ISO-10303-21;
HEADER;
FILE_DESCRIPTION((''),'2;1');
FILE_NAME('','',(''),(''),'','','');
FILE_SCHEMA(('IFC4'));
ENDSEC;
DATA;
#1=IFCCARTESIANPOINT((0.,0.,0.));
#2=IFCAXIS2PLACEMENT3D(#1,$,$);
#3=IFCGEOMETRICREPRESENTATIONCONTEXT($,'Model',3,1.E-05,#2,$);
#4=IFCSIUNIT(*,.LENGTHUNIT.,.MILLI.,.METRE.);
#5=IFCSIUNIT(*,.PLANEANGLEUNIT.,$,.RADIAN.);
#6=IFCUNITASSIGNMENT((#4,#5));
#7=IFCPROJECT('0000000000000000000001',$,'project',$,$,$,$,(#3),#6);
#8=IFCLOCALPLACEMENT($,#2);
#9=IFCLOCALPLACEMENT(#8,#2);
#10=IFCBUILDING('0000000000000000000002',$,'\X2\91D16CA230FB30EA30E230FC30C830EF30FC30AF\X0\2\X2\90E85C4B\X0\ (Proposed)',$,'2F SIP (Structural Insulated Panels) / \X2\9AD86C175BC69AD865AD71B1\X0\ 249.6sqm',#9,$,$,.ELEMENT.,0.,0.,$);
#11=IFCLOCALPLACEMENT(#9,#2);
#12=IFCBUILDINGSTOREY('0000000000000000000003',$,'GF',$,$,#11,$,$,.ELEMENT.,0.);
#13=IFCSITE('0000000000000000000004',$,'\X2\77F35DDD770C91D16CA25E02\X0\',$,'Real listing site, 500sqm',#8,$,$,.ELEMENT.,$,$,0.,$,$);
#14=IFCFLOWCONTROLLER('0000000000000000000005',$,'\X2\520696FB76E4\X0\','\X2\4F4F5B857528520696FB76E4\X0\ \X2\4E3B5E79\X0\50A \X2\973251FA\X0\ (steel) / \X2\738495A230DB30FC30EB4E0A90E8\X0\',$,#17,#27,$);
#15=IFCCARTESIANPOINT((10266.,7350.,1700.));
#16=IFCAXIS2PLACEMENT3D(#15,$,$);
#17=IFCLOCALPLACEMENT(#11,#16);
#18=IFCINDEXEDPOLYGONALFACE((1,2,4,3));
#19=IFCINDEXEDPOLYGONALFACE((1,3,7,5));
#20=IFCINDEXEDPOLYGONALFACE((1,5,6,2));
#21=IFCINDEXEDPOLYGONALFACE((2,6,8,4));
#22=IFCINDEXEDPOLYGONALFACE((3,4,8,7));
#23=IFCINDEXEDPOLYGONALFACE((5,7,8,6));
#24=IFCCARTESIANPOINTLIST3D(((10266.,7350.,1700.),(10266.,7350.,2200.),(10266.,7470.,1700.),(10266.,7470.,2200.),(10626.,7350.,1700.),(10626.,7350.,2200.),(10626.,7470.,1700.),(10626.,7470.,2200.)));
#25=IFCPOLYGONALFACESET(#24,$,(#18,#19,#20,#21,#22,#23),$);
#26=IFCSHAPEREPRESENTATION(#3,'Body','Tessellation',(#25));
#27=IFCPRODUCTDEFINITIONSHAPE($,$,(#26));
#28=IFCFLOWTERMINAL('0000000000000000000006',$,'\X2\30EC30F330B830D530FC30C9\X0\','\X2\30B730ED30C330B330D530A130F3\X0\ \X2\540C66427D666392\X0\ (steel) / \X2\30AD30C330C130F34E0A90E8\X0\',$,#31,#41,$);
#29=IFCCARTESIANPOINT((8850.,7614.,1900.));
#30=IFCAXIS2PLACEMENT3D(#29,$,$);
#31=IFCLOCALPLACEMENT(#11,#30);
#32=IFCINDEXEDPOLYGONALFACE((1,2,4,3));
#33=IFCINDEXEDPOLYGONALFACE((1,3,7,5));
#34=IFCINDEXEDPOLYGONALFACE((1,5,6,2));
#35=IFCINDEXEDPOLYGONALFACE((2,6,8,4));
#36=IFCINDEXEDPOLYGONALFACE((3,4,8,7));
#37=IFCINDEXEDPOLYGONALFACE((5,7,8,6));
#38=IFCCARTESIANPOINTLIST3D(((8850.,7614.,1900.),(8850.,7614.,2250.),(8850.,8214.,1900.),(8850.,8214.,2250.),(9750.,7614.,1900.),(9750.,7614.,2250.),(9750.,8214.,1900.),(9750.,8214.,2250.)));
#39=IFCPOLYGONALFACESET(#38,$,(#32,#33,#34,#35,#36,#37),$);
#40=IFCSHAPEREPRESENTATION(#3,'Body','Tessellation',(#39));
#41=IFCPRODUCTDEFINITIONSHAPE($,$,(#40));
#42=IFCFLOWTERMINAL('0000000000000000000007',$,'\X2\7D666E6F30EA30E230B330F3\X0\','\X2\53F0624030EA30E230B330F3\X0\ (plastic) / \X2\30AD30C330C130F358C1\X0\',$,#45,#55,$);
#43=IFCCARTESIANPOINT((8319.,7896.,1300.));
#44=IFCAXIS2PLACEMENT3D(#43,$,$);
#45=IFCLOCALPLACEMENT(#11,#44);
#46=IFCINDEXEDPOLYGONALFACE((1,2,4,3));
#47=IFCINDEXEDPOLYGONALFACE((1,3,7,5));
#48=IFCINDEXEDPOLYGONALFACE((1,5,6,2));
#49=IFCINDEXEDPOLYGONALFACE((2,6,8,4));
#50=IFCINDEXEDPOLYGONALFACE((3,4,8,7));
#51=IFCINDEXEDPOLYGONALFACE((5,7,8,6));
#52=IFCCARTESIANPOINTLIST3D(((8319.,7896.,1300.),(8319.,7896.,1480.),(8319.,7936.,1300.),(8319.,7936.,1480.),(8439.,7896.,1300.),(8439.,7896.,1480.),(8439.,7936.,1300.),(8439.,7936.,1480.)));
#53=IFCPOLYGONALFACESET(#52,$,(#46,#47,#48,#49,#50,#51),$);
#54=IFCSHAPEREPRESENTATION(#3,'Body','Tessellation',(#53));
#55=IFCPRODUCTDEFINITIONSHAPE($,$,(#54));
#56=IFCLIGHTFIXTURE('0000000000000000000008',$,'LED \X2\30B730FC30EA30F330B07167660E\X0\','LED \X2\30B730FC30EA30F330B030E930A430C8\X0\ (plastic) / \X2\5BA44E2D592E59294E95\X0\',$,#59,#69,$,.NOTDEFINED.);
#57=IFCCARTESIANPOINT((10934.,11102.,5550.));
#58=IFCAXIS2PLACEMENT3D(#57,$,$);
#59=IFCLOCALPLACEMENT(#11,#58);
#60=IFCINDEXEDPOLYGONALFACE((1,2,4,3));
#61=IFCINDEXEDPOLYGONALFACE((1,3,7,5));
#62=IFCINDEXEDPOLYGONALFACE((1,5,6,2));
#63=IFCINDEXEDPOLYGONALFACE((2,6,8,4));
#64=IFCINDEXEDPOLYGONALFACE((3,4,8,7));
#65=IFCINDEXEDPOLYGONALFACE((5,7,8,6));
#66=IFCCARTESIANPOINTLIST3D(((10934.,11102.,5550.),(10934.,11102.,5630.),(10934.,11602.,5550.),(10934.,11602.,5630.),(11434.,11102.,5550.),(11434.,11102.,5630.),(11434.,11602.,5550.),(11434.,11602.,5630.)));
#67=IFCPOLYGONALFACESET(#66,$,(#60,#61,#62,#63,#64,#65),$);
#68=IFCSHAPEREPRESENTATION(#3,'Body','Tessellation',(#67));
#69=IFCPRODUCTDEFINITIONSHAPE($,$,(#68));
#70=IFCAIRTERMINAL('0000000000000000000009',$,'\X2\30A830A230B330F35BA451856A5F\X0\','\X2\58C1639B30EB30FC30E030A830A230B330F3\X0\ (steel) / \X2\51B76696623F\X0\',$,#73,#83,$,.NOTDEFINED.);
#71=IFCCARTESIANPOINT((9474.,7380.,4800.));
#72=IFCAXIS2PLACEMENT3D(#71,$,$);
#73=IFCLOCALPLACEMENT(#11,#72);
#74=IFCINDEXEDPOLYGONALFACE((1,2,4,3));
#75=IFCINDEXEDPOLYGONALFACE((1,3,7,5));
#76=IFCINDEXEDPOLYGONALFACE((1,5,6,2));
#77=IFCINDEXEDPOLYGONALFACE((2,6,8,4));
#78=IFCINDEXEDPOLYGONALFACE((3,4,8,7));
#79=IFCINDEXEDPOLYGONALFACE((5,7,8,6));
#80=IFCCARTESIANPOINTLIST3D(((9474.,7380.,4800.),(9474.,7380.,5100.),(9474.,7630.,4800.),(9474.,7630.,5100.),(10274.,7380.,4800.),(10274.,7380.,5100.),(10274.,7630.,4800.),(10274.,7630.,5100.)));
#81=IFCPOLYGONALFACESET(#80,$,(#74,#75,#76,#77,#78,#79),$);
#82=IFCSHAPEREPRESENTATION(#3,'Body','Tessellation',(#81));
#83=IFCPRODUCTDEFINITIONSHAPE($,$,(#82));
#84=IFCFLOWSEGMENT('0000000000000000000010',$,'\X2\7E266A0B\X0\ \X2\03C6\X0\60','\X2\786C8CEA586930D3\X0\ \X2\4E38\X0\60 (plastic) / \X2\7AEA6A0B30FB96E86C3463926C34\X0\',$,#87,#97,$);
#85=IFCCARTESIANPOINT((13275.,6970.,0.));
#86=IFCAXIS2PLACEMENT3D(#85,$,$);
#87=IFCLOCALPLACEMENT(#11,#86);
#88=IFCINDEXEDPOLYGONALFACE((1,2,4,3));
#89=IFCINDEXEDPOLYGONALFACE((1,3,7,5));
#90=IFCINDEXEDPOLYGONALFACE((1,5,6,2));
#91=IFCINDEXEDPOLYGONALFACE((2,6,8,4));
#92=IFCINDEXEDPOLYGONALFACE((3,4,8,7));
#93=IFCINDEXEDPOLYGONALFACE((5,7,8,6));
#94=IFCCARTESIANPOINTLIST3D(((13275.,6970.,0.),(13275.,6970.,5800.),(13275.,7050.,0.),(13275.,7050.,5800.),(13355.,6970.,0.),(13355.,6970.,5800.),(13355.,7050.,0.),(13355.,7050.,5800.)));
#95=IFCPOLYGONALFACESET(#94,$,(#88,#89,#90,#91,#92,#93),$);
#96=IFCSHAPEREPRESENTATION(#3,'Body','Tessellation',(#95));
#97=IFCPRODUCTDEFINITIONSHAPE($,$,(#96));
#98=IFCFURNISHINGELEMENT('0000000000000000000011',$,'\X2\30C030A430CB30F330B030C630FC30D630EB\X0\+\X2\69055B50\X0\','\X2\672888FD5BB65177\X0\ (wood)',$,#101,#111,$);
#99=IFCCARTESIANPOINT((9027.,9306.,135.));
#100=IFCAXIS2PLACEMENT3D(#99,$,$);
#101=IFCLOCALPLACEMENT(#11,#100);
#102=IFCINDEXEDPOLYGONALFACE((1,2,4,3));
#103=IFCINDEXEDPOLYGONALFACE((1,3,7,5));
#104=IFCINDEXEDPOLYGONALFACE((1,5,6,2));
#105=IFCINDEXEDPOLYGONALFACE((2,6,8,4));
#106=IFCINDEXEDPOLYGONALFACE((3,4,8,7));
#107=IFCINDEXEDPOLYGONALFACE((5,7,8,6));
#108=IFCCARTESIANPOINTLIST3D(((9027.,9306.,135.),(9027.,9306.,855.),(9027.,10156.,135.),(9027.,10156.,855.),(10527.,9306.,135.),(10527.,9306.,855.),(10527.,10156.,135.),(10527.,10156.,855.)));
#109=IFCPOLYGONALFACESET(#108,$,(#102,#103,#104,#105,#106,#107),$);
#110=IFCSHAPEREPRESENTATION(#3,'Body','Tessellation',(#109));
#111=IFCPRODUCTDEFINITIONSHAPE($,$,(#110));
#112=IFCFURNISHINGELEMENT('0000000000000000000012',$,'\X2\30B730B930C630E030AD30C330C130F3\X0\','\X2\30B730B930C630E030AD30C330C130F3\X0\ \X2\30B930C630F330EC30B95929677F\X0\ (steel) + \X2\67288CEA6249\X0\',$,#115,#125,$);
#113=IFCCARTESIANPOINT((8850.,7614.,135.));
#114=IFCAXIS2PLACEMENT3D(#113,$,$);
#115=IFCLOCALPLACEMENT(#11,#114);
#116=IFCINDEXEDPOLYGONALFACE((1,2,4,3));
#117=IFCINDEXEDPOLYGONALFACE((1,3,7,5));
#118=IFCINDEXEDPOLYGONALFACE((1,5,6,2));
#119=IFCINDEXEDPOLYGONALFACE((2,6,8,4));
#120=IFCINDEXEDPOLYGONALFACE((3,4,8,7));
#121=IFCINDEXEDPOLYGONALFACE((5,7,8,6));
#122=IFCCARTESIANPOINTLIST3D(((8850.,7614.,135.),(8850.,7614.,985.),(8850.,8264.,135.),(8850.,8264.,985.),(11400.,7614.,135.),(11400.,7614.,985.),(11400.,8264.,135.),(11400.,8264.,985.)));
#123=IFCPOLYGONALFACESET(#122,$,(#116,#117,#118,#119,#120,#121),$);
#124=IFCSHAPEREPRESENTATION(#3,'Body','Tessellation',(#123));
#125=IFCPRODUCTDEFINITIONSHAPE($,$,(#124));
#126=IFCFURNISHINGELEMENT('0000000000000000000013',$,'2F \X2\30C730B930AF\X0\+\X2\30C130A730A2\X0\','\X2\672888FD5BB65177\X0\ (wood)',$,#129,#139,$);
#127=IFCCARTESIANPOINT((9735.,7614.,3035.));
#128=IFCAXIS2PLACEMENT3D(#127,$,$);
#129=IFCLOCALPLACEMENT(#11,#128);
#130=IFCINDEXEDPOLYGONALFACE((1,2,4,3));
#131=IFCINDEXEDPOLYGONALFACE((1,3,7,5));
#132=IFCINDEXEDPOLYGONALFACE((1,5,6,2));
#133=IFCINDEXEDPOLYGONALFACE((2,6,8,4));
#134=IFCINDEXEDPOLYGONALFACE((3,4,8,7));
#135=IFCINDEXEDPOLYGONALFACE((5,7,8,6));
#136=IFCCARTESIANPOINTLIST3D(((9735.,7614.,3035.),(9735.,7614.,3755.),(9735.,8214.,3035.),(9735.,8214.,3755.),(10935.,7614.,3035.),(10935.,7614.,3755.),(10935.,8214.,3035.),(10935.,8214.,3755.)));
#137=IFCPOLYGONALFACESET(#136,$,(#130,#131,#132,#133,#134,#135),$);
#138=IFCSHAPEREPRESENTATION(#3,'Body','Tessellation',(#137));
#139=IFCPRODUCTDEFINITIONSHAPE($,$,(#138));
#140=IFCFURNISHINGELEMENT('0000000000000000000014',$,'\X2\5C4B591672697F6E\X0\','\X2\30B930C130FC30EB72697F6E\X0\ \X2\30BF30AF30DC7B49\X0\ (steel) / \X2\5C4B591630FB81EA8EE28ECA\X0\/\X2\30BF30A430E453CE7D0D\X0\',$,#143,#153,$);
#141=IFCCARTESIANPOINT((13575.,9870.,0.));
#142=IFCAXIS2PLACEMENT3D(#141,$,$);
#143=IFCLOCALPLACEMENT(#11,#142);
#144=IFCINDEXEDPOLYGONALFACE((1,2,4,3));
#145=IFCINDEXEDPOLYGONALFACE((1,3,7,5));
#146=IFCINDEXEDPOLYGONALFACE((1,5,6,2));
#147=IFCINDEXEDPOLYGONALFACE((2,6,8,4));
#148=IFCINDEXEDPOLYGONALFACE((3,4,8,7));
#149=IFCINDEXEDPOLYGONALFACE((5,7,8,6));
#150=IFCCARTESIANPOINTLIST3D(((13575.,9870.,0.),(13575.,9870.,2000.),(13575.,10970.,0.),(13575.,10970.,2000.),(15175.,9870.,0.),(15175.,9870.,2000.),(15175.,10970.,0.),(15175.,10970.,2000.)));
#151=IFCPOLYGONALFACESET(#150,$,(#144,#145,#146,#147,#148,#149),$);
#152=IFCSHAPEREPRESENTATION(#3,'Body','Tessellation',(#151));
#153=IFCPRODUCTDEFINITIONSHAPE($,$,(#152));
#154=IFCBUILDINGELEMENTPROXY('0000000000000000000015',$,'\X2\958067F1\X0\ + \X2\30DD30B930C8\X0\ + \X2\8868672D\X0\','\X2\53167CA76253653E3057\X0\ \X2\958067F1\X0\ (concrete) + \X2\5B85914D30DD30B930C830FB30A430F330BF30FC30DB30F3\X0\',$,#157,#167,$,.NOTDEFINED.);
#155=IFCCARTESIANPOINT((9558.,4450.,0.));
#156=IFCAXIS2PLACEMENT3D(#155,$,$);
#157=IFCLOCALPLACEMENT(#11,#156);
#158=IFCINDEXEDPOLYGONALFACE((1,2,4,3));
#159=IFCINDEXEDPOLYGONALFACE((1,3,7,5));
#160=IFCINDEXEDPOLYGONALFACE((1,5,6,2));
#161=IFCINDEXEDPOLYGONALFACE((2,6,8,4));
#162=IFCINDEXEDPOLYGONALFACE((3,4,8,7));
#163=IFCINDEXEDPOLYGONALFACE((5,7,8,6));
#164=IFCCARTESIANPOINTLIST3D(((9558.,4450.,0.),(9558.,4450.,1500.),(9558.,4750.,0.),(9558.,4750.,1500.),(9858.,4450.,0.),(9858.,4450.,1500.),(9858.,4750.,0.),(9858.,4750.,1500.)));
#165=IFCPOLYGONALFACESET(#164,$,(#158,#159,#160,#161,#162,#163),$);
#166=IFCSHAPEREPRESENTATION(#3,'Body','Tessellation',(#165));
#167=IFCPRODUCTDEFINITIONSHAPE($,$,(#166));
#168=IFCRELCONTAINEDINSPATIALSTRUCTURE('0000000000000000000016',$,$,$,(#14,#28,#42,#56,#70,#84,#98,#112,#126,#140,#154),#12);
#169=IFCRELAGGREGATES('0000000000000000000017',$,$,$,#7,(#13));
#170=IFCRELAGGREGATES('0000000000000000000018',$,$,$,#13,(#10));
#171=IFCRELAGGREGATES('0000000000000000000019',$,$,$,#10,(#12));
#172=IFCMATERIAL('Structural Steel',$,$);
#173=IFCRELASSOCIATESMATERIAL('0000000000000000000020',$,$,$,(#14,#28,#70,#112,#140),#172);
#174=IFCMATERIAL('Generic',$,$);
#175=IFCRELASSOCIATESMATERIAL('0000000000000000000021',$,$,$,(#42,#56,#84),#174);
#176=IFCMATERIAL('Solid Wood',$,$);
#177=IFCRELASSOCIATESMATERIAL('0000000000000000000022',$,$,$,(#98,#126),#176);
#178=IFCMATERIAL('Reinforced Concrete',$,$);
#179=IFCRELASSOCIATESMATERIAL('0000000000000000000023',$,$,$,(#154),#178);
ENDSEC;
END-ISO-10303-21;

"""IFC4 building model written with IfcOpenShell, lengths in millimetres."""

from ifc_helpers import new_model, si_unit, frame, frame_2d, origin, place, context, project, spatial, rectangle, extrude, material, element, save


model = new_model("IFC4")

# Units and contexts
model_context = context("Model", 3, precision=1e-05, world=origin())
ifc_project = project(units=[si_unit("LENGTHUNIT", "METRE", prefix="MILLI"), si_unit("PLANEANGLEUNIT", "RADIAN")], contexts=[model_context])

# Site, building, storey
site_placement = place(None, origin())
site = spatial("IfcSite", under=ifc_project, at=site_placement, Name="石川県金沢市", ObjectType="Real listing site, 500sqm", CompositionType="ELEMENT", RefElevation=0.0)
building_placement = place(site_placement, origin())
building = spatial("IfcBuilding", under=site, at=building_placement, Name="金沢・リモートワーク2部屋 (Proposed)", ObjectType="2F SIP (Structural Insulated Panels) / 高気密高断熱 249.6sqm", CompositionType="ELEMENT", ElevationOfRefHeight=0.0, ElevationOfTerrain=0.0)
storey_placement = place(building_placement, origin())
storey = spatial("IfcBuildingStorey", under=building, at=storey_placement, Name="GF", CompositionType="ELEMENT", Elevation=0.0)

# Shared definitions
ifc_material_1 = material(Name="Solid Wood")
ifc_material_2 = material(Name="Structural Steel")

# Shared definitions
ifc_material_3 = material(Name="Reinforced Concrete")

# Flow controller
flow_controller_placement = place(storey_placement, frame((10266.0, 7350.0, 1700.0)))
element("IfcFlowController", 1, at=flow_controller_placement, inside=storey, material=ifc_material_2, Name="分電盤", Description="住宅用分電盤 主幹50A 露出 (steel) / 玄関ホール上部", context=model_context, shape_type="SweptSolid", body=[
    extrude(rectangle(XDim=360.0, YDim=120.0, at=frame_2d((180.0, 60.0))), frame((10266.0, 7350.0, 1700.0)), (0.0, 0.0, 1.0), 500.0),
])

# Flow terminals
flow_terminal_1_placement = place(storey_placement, frame((8850.0, 7614.0, 1900.0)))
element("IfcFlowTerminal", 2, at=flow_terminal_1_placement, inside=storey, material=ifc_material_2, Name="レンジフード", Description="シロッコファン 同時給排 (steel) / キッチン上部", context=model_context, shape_type="SweptSolid", body=[
    extrude(rectangle(XDim=900.0, YDim=600.0, at=frame_2d((450.0, 300.0))), frame((8850.0, 7614.0, 1900.0)), (0.0, 0.0, 1.0), 350.0),
])
ifc_material_4 = material(Name="Generic")
flow_terminal_2_placement = place(storey_placement, frame((8319.0, 7896.0, 1300.0)))
element("IfcFlowTerminal", 3, at=flow_terminal_2_placement, inside=storey, material=ifc_material_4, Name="給湯リモコン", Description="台所リモコン (plastic) / キッチン壁", context=model_context, shape_type="SweptSolid", body=[
    extrude(rectangle(XDim=120.0, YDim=40.0, at=frame_2d((60.0, 20.0))), frame((8319.0, 7896.0, 1300.0)), (0.0, 0.0, 1.0), 180.0),
])

# Light fixture
light_fixture_placement = place(storey_placement, frame((10934.0, 11102.0, 5550.0)))
element("IfcLightFixture", 4, at=light_fixture_placement, inside=storey, material=ifc_material_4, Name="LED シーリング照明", Description="LED シーリングライト (plastic) / 室中央天井", PredefinedType="NOTDEFINED", context=model_context, shape_type="SweptSolid", body=[
    extrude(rectangle(XDim=500.0, YDim=500.0, at=frame_2d((250.0, 250.0))), frame((10934.0, 11102.0, 5550.0)), (0.0, 0.0, 1.0), 80.0),
])

# Air terminal
air_terminal_placement = place(storey_placement, frame((9474.0, 7380.0, 4800.0)))
element("IfcAirTerminal", 5, at=air_terminal_placement, inside=storey, material=ifc_material_2, Name="エアコン室内機", Description="壁掛ルームエアコン (steel) / 冷暖房", PredefinedType="NOTDEFINED", context=model_context, shape_type="SweptSolid", body=[
    extrude(rectangle(XDim=800.0, YDim=250.0, at=frame_2d((400.0, 125.0))), frame((9474.0, 7380.0, 4800.0)), (0.0, 0.0, 1.0), 300.0),
])

# Flow segment
flow_segment_placement = place(storey_placement, frame((13275.0, 6970.0, 0.0)))
element("IfcFlowSegment", 6, at=flow_segment_placement, inside=storey, material=ifc_material_4, Name="縦樋 φ60", Description="硬質塩ビ 丸60 (plastic) / 竪樋・雨水排水", context=model_context, shape_type="SweptSolid", body=[
    extrude(rectangle(XDim=80.0, YDim=80.0, at=frame_2d((40.0, 40.0))), frame((13275.0, 6970.0, 0.0)), (0.0, 0.0, 1.0), 5800.0),
])

# Furnishing elements
furnishing_1_placement = place(storey_placement, frame((9027.0, 9306.0, 135.0)))
element("IfcFurnishingElement", 7, at=furnishing_1_placement, inside=storey, material=ifc_material_1, Name="ダイニングテーブル+椅子", Description="木製家具 (wood)", context=model_context, shape_type="SweptSolid", body=[
    extrude(rectangle(XDim=1500.0, YDim=850.0, at=frame_2d((750.0, 425.0))), frame((9027.0, 9306.0, 135.0)), (0.0, 0.0, 1.0), 720.0),
])
furnishing_2_placement = place(storey_placement, frame((8850.0, 7614.0, 135.0)))
element("IfcFurnishingElement", 8, at=furnishing_2_placement, inside=storey, material=ifc_material_2, Name="システムキッチン", Description="システムキッチン ステンレス天板 (steel) + 木質扉", context=model_context, shape_type="SweptSolid", body=[
    extrude(rectangle(XDim=2550.0, YDim=650.0, at=frame_2d((1275.0, 325.0))), frame((8850.0, 7614.0, 135.0)), (0.0, 0.0, 1.0), 850.0),
])
furnishing_3_placement = place(storey_placement, frame((9735.0, 7614.0, 3035.0)))
element("IfcFurnishingElement", 9, at=furnishing_3_placement, inside=storey, material=ifc_material_1, Name="2F デスク+チェア", Description="木製家具 (wood)", context=model_context, shape_type="SweptSolid", body=[
    extrude(rectangle(XDim=1200.0, YDim=600.0, at=frame_2d((600.0, 300.0))), frame((9735.0, 7614.0, 3035.0)), (0.0, 0.0, 1.0), 720.0),
])
furnishing_4_placement = place(storey_placement, frame((13575.0, 9870.0, 0.0)))
element("IfcFurnishingElement", 10, at=furnishing_4_placement, inside=storey, material=ifc_material_2, Name="屋外物置", Description="スチール物置 タクボ等 (steel) / 屋外・自転車/タイヤ収納", context=model_context, shape_type="SweptSolid", body=[
    extrude(rectangle(XDim=1600.0, YDim=1100.0, at=frame_2d((800.0, 550.0))), frame((13575.0, 9870.0, 0.0)), (0.0, 0.0, 1.0), 2000.0),
])

# Building element proxy
proxy_placement = place(storey_placement, frame((9558.0, 4450.0, 0.0)))
element("IfcBuildingElementProxy", 11, at=proxy_placement, inside=storey, material=ifc_material_3, Name="門柱 + ポスト + 表札", Description="化粧打放し 門柱 (concrete) + 宅配ポスト・インターホン", PredefinedType="NOTDEFINED", context=model_context, shape_type="SweptSolid", body=[
    extrude(rectangle(XDim=300.0, YDim=300.0, at=frame_2d((150.0, 150.0))), frame((9558.0, 4450.0, 0.0)), (0.0, 0.0, 1.0), 1500.0),
])

save(model, "model.ifc")
